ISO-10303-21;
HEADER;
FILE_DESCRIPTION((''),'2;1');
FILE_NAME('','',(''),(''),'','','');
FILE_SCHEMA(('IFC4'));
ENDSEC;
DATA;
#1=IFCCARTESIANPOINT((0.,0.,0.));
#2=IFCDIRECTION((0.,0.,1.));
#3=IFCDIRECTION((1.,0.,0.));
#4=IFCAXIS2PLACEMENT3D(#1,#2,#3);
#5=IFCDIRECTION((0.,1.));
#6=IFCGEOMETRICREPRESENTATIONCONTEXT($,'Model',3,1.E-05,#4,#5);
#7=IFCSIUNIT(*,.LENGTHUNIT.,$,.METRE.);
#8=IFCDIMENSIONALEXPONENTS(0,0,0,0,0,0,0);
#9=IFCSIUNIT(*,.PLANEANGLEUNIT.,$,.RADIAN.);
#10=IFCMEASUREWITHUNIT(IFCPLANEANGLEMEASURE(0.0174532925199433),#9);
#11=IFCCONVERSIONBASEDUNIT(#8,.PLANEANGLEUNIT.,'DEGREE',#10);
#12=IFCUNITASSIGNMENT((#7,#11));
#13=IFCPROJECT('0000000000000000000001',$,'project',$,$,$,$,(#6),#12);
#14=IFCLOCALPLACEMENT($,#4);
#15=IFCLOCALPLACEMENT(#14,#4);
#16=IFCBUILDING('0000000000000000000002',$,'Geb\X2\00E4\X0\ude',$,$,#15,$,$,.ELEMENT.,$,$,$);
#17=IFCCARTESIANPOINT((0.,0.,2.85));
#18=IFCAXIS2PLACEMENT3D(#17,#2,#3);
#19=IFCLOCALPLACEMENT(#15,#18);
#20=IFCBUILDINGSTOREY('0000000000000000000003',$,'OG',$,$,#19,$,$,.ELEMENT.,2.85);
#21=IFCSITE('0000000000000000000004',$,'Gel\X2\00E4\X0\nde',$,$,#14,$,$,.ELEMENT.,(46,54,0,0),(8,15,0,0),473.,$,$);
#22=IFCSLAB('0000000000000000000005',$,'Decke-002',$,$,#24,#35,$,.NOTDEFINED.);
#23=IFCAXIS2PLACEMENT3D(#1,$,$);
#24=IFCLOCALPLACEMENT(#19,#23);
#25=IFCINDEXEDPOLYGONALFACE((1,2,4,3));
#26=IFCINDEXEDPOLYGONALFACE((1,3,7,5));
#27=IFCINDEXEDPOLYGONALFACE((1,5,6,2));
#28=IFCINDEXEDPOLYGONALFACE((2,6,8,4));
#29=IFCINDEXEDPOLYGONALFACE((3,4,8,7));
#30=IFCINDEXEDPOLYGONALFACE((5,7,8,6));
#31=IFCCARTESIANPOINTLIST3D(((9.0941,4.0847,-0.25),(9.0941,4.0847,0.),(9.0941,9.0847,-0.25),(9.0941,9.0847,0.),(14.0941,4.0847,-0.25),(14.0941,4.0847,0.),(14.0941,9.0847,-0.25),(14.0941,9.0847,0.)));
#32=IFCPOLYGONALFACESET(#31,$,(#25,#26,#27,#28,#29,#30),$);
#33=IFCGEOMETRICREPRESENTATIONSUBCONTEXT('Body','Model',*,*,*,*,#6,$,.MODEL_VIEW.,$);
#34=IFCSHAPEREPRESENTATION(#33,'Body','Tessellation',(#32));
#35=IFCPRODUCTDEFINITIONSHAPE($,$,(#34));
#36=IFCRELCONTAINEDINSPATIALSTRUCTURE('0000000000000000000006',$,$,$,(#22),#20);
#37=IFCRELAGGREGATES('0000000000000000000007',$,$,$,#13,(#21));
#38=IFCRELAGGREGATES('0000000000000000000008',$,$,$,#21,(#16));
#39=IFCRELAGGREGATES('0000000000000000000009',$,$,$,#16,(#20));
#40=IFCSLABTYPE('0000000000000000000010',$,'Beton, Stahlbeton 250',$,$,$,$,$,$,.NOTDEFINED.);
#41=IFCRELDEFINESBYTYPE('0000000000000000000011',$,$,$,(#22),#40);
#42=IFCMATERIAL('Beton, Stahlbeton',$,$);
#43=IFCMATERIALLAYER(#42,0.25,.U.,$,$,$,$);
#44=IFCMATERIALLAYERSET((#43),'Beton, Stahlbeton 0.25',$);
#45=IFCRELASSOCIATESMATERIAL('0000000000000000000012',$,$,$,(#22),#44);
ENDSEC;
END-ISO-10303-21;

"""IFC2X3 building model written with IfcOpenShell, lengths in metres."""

from ifc_helpers import new_model, entity, si_unit, converted_unit, direction, frame, origin_with_axes, place, context, subcontext, project, spatial, polyline, outline, extrude, material, layer, layer_set, layer_usage, type_object, element, save


model = new_model("IFC2X3")

# Units and contexts
model_context = context("Model", 3, precision=1e-05, world=origin_with_axes(), true_north=direction((0.0, 1.0)))
body_context = subcontext(model_context, "Body", "Model", "MODEL_VIEW")
ifc_project = project(units=[si_unit("LENGTHUNIT", "METRE"), converted_unit("PLANEANGLEUNIT", "DEGREE", entity("IfcPlaneAngleMeasure", 0.0174532925199433), si_unit("PLANEANGLEUNIT", "RADIAN"), dimensions=[0, 0, 0, 0, 0, 0, 0])], contexts=[model_context])

# Site, building, storey
site_placement = place(None, origin_with_axes())
site = spatial("IfcSite", under=ifc_project, at=site_placement, Name="Gelände", CompositionType="ELEMENT", RefLatitude=(46, 54, 0, 0), RefLongitude=(8, 15, 0, 0), RefElevation=473.0)
building_placement = place(site_placement, origin_with_axes())
building = spatial("IfcBuilding", under=site, at=building_placement, Name="Gebäude", CompositionType="ELEMENT")
storey_placement = place(building_placement, frame((0.0, 0.0, 2.85), z_axis=(0.0, 0.0, 1.0), x_axis=(1.0, 0.0, 0.0)))
storey = spatial("IfcBuildingStorey", under=building, at=storey_placement, Name="OG", CompositionType="ELEMENT", Elevation=2.85)

# Slab
ifc_material_1 = material(Name="Beton, Stahlbeton")
ifc_layer = layer(ifc_material_1, 0.25, ventilated="UNKNOWN")
ifc_layer_set = layer_set([ifc_layer], Name="Beton, Stahlbeton 0.25")
ifc_layer_usage = layer_usage(ifc_layer_set, "AXIS3", "NEGATIVE", 0.25)
slab_type = type_object("IfcSlabType", Name="Beton, Stahlbeton 250", PredefinedType="NOTDEFINED")
slab_placement = place(storey_placement, frame((9.0941, 4.0847, 0.0), z_axis=(0.0, 0.0, 1.0), x_axis=(1.0, 0.0, 0.0)))
element("IfcSlab", 1, at=slab_placement, inside=storey, type_object=slab_type, material=ifc_layer_usage, Name="Decke-002", PredefinedType="NOTDEFINED", context=body_context, shape_type="SweptSolid", body=[
    extrude(outline(polyline([(0.0, 0.0), (5.0, 0.0), (5.0, 5.0), (0.0, 5.0), (0.0, 0.0)])), frame((0.0, 0.0, -0.25), z_axis=(0.0, 0.0, 1.0), x_axis=(1.0, 0.0, 0.0)), (0.0, 0.0, 1.0), 0.25),
])

save(model, "model.ifc")
